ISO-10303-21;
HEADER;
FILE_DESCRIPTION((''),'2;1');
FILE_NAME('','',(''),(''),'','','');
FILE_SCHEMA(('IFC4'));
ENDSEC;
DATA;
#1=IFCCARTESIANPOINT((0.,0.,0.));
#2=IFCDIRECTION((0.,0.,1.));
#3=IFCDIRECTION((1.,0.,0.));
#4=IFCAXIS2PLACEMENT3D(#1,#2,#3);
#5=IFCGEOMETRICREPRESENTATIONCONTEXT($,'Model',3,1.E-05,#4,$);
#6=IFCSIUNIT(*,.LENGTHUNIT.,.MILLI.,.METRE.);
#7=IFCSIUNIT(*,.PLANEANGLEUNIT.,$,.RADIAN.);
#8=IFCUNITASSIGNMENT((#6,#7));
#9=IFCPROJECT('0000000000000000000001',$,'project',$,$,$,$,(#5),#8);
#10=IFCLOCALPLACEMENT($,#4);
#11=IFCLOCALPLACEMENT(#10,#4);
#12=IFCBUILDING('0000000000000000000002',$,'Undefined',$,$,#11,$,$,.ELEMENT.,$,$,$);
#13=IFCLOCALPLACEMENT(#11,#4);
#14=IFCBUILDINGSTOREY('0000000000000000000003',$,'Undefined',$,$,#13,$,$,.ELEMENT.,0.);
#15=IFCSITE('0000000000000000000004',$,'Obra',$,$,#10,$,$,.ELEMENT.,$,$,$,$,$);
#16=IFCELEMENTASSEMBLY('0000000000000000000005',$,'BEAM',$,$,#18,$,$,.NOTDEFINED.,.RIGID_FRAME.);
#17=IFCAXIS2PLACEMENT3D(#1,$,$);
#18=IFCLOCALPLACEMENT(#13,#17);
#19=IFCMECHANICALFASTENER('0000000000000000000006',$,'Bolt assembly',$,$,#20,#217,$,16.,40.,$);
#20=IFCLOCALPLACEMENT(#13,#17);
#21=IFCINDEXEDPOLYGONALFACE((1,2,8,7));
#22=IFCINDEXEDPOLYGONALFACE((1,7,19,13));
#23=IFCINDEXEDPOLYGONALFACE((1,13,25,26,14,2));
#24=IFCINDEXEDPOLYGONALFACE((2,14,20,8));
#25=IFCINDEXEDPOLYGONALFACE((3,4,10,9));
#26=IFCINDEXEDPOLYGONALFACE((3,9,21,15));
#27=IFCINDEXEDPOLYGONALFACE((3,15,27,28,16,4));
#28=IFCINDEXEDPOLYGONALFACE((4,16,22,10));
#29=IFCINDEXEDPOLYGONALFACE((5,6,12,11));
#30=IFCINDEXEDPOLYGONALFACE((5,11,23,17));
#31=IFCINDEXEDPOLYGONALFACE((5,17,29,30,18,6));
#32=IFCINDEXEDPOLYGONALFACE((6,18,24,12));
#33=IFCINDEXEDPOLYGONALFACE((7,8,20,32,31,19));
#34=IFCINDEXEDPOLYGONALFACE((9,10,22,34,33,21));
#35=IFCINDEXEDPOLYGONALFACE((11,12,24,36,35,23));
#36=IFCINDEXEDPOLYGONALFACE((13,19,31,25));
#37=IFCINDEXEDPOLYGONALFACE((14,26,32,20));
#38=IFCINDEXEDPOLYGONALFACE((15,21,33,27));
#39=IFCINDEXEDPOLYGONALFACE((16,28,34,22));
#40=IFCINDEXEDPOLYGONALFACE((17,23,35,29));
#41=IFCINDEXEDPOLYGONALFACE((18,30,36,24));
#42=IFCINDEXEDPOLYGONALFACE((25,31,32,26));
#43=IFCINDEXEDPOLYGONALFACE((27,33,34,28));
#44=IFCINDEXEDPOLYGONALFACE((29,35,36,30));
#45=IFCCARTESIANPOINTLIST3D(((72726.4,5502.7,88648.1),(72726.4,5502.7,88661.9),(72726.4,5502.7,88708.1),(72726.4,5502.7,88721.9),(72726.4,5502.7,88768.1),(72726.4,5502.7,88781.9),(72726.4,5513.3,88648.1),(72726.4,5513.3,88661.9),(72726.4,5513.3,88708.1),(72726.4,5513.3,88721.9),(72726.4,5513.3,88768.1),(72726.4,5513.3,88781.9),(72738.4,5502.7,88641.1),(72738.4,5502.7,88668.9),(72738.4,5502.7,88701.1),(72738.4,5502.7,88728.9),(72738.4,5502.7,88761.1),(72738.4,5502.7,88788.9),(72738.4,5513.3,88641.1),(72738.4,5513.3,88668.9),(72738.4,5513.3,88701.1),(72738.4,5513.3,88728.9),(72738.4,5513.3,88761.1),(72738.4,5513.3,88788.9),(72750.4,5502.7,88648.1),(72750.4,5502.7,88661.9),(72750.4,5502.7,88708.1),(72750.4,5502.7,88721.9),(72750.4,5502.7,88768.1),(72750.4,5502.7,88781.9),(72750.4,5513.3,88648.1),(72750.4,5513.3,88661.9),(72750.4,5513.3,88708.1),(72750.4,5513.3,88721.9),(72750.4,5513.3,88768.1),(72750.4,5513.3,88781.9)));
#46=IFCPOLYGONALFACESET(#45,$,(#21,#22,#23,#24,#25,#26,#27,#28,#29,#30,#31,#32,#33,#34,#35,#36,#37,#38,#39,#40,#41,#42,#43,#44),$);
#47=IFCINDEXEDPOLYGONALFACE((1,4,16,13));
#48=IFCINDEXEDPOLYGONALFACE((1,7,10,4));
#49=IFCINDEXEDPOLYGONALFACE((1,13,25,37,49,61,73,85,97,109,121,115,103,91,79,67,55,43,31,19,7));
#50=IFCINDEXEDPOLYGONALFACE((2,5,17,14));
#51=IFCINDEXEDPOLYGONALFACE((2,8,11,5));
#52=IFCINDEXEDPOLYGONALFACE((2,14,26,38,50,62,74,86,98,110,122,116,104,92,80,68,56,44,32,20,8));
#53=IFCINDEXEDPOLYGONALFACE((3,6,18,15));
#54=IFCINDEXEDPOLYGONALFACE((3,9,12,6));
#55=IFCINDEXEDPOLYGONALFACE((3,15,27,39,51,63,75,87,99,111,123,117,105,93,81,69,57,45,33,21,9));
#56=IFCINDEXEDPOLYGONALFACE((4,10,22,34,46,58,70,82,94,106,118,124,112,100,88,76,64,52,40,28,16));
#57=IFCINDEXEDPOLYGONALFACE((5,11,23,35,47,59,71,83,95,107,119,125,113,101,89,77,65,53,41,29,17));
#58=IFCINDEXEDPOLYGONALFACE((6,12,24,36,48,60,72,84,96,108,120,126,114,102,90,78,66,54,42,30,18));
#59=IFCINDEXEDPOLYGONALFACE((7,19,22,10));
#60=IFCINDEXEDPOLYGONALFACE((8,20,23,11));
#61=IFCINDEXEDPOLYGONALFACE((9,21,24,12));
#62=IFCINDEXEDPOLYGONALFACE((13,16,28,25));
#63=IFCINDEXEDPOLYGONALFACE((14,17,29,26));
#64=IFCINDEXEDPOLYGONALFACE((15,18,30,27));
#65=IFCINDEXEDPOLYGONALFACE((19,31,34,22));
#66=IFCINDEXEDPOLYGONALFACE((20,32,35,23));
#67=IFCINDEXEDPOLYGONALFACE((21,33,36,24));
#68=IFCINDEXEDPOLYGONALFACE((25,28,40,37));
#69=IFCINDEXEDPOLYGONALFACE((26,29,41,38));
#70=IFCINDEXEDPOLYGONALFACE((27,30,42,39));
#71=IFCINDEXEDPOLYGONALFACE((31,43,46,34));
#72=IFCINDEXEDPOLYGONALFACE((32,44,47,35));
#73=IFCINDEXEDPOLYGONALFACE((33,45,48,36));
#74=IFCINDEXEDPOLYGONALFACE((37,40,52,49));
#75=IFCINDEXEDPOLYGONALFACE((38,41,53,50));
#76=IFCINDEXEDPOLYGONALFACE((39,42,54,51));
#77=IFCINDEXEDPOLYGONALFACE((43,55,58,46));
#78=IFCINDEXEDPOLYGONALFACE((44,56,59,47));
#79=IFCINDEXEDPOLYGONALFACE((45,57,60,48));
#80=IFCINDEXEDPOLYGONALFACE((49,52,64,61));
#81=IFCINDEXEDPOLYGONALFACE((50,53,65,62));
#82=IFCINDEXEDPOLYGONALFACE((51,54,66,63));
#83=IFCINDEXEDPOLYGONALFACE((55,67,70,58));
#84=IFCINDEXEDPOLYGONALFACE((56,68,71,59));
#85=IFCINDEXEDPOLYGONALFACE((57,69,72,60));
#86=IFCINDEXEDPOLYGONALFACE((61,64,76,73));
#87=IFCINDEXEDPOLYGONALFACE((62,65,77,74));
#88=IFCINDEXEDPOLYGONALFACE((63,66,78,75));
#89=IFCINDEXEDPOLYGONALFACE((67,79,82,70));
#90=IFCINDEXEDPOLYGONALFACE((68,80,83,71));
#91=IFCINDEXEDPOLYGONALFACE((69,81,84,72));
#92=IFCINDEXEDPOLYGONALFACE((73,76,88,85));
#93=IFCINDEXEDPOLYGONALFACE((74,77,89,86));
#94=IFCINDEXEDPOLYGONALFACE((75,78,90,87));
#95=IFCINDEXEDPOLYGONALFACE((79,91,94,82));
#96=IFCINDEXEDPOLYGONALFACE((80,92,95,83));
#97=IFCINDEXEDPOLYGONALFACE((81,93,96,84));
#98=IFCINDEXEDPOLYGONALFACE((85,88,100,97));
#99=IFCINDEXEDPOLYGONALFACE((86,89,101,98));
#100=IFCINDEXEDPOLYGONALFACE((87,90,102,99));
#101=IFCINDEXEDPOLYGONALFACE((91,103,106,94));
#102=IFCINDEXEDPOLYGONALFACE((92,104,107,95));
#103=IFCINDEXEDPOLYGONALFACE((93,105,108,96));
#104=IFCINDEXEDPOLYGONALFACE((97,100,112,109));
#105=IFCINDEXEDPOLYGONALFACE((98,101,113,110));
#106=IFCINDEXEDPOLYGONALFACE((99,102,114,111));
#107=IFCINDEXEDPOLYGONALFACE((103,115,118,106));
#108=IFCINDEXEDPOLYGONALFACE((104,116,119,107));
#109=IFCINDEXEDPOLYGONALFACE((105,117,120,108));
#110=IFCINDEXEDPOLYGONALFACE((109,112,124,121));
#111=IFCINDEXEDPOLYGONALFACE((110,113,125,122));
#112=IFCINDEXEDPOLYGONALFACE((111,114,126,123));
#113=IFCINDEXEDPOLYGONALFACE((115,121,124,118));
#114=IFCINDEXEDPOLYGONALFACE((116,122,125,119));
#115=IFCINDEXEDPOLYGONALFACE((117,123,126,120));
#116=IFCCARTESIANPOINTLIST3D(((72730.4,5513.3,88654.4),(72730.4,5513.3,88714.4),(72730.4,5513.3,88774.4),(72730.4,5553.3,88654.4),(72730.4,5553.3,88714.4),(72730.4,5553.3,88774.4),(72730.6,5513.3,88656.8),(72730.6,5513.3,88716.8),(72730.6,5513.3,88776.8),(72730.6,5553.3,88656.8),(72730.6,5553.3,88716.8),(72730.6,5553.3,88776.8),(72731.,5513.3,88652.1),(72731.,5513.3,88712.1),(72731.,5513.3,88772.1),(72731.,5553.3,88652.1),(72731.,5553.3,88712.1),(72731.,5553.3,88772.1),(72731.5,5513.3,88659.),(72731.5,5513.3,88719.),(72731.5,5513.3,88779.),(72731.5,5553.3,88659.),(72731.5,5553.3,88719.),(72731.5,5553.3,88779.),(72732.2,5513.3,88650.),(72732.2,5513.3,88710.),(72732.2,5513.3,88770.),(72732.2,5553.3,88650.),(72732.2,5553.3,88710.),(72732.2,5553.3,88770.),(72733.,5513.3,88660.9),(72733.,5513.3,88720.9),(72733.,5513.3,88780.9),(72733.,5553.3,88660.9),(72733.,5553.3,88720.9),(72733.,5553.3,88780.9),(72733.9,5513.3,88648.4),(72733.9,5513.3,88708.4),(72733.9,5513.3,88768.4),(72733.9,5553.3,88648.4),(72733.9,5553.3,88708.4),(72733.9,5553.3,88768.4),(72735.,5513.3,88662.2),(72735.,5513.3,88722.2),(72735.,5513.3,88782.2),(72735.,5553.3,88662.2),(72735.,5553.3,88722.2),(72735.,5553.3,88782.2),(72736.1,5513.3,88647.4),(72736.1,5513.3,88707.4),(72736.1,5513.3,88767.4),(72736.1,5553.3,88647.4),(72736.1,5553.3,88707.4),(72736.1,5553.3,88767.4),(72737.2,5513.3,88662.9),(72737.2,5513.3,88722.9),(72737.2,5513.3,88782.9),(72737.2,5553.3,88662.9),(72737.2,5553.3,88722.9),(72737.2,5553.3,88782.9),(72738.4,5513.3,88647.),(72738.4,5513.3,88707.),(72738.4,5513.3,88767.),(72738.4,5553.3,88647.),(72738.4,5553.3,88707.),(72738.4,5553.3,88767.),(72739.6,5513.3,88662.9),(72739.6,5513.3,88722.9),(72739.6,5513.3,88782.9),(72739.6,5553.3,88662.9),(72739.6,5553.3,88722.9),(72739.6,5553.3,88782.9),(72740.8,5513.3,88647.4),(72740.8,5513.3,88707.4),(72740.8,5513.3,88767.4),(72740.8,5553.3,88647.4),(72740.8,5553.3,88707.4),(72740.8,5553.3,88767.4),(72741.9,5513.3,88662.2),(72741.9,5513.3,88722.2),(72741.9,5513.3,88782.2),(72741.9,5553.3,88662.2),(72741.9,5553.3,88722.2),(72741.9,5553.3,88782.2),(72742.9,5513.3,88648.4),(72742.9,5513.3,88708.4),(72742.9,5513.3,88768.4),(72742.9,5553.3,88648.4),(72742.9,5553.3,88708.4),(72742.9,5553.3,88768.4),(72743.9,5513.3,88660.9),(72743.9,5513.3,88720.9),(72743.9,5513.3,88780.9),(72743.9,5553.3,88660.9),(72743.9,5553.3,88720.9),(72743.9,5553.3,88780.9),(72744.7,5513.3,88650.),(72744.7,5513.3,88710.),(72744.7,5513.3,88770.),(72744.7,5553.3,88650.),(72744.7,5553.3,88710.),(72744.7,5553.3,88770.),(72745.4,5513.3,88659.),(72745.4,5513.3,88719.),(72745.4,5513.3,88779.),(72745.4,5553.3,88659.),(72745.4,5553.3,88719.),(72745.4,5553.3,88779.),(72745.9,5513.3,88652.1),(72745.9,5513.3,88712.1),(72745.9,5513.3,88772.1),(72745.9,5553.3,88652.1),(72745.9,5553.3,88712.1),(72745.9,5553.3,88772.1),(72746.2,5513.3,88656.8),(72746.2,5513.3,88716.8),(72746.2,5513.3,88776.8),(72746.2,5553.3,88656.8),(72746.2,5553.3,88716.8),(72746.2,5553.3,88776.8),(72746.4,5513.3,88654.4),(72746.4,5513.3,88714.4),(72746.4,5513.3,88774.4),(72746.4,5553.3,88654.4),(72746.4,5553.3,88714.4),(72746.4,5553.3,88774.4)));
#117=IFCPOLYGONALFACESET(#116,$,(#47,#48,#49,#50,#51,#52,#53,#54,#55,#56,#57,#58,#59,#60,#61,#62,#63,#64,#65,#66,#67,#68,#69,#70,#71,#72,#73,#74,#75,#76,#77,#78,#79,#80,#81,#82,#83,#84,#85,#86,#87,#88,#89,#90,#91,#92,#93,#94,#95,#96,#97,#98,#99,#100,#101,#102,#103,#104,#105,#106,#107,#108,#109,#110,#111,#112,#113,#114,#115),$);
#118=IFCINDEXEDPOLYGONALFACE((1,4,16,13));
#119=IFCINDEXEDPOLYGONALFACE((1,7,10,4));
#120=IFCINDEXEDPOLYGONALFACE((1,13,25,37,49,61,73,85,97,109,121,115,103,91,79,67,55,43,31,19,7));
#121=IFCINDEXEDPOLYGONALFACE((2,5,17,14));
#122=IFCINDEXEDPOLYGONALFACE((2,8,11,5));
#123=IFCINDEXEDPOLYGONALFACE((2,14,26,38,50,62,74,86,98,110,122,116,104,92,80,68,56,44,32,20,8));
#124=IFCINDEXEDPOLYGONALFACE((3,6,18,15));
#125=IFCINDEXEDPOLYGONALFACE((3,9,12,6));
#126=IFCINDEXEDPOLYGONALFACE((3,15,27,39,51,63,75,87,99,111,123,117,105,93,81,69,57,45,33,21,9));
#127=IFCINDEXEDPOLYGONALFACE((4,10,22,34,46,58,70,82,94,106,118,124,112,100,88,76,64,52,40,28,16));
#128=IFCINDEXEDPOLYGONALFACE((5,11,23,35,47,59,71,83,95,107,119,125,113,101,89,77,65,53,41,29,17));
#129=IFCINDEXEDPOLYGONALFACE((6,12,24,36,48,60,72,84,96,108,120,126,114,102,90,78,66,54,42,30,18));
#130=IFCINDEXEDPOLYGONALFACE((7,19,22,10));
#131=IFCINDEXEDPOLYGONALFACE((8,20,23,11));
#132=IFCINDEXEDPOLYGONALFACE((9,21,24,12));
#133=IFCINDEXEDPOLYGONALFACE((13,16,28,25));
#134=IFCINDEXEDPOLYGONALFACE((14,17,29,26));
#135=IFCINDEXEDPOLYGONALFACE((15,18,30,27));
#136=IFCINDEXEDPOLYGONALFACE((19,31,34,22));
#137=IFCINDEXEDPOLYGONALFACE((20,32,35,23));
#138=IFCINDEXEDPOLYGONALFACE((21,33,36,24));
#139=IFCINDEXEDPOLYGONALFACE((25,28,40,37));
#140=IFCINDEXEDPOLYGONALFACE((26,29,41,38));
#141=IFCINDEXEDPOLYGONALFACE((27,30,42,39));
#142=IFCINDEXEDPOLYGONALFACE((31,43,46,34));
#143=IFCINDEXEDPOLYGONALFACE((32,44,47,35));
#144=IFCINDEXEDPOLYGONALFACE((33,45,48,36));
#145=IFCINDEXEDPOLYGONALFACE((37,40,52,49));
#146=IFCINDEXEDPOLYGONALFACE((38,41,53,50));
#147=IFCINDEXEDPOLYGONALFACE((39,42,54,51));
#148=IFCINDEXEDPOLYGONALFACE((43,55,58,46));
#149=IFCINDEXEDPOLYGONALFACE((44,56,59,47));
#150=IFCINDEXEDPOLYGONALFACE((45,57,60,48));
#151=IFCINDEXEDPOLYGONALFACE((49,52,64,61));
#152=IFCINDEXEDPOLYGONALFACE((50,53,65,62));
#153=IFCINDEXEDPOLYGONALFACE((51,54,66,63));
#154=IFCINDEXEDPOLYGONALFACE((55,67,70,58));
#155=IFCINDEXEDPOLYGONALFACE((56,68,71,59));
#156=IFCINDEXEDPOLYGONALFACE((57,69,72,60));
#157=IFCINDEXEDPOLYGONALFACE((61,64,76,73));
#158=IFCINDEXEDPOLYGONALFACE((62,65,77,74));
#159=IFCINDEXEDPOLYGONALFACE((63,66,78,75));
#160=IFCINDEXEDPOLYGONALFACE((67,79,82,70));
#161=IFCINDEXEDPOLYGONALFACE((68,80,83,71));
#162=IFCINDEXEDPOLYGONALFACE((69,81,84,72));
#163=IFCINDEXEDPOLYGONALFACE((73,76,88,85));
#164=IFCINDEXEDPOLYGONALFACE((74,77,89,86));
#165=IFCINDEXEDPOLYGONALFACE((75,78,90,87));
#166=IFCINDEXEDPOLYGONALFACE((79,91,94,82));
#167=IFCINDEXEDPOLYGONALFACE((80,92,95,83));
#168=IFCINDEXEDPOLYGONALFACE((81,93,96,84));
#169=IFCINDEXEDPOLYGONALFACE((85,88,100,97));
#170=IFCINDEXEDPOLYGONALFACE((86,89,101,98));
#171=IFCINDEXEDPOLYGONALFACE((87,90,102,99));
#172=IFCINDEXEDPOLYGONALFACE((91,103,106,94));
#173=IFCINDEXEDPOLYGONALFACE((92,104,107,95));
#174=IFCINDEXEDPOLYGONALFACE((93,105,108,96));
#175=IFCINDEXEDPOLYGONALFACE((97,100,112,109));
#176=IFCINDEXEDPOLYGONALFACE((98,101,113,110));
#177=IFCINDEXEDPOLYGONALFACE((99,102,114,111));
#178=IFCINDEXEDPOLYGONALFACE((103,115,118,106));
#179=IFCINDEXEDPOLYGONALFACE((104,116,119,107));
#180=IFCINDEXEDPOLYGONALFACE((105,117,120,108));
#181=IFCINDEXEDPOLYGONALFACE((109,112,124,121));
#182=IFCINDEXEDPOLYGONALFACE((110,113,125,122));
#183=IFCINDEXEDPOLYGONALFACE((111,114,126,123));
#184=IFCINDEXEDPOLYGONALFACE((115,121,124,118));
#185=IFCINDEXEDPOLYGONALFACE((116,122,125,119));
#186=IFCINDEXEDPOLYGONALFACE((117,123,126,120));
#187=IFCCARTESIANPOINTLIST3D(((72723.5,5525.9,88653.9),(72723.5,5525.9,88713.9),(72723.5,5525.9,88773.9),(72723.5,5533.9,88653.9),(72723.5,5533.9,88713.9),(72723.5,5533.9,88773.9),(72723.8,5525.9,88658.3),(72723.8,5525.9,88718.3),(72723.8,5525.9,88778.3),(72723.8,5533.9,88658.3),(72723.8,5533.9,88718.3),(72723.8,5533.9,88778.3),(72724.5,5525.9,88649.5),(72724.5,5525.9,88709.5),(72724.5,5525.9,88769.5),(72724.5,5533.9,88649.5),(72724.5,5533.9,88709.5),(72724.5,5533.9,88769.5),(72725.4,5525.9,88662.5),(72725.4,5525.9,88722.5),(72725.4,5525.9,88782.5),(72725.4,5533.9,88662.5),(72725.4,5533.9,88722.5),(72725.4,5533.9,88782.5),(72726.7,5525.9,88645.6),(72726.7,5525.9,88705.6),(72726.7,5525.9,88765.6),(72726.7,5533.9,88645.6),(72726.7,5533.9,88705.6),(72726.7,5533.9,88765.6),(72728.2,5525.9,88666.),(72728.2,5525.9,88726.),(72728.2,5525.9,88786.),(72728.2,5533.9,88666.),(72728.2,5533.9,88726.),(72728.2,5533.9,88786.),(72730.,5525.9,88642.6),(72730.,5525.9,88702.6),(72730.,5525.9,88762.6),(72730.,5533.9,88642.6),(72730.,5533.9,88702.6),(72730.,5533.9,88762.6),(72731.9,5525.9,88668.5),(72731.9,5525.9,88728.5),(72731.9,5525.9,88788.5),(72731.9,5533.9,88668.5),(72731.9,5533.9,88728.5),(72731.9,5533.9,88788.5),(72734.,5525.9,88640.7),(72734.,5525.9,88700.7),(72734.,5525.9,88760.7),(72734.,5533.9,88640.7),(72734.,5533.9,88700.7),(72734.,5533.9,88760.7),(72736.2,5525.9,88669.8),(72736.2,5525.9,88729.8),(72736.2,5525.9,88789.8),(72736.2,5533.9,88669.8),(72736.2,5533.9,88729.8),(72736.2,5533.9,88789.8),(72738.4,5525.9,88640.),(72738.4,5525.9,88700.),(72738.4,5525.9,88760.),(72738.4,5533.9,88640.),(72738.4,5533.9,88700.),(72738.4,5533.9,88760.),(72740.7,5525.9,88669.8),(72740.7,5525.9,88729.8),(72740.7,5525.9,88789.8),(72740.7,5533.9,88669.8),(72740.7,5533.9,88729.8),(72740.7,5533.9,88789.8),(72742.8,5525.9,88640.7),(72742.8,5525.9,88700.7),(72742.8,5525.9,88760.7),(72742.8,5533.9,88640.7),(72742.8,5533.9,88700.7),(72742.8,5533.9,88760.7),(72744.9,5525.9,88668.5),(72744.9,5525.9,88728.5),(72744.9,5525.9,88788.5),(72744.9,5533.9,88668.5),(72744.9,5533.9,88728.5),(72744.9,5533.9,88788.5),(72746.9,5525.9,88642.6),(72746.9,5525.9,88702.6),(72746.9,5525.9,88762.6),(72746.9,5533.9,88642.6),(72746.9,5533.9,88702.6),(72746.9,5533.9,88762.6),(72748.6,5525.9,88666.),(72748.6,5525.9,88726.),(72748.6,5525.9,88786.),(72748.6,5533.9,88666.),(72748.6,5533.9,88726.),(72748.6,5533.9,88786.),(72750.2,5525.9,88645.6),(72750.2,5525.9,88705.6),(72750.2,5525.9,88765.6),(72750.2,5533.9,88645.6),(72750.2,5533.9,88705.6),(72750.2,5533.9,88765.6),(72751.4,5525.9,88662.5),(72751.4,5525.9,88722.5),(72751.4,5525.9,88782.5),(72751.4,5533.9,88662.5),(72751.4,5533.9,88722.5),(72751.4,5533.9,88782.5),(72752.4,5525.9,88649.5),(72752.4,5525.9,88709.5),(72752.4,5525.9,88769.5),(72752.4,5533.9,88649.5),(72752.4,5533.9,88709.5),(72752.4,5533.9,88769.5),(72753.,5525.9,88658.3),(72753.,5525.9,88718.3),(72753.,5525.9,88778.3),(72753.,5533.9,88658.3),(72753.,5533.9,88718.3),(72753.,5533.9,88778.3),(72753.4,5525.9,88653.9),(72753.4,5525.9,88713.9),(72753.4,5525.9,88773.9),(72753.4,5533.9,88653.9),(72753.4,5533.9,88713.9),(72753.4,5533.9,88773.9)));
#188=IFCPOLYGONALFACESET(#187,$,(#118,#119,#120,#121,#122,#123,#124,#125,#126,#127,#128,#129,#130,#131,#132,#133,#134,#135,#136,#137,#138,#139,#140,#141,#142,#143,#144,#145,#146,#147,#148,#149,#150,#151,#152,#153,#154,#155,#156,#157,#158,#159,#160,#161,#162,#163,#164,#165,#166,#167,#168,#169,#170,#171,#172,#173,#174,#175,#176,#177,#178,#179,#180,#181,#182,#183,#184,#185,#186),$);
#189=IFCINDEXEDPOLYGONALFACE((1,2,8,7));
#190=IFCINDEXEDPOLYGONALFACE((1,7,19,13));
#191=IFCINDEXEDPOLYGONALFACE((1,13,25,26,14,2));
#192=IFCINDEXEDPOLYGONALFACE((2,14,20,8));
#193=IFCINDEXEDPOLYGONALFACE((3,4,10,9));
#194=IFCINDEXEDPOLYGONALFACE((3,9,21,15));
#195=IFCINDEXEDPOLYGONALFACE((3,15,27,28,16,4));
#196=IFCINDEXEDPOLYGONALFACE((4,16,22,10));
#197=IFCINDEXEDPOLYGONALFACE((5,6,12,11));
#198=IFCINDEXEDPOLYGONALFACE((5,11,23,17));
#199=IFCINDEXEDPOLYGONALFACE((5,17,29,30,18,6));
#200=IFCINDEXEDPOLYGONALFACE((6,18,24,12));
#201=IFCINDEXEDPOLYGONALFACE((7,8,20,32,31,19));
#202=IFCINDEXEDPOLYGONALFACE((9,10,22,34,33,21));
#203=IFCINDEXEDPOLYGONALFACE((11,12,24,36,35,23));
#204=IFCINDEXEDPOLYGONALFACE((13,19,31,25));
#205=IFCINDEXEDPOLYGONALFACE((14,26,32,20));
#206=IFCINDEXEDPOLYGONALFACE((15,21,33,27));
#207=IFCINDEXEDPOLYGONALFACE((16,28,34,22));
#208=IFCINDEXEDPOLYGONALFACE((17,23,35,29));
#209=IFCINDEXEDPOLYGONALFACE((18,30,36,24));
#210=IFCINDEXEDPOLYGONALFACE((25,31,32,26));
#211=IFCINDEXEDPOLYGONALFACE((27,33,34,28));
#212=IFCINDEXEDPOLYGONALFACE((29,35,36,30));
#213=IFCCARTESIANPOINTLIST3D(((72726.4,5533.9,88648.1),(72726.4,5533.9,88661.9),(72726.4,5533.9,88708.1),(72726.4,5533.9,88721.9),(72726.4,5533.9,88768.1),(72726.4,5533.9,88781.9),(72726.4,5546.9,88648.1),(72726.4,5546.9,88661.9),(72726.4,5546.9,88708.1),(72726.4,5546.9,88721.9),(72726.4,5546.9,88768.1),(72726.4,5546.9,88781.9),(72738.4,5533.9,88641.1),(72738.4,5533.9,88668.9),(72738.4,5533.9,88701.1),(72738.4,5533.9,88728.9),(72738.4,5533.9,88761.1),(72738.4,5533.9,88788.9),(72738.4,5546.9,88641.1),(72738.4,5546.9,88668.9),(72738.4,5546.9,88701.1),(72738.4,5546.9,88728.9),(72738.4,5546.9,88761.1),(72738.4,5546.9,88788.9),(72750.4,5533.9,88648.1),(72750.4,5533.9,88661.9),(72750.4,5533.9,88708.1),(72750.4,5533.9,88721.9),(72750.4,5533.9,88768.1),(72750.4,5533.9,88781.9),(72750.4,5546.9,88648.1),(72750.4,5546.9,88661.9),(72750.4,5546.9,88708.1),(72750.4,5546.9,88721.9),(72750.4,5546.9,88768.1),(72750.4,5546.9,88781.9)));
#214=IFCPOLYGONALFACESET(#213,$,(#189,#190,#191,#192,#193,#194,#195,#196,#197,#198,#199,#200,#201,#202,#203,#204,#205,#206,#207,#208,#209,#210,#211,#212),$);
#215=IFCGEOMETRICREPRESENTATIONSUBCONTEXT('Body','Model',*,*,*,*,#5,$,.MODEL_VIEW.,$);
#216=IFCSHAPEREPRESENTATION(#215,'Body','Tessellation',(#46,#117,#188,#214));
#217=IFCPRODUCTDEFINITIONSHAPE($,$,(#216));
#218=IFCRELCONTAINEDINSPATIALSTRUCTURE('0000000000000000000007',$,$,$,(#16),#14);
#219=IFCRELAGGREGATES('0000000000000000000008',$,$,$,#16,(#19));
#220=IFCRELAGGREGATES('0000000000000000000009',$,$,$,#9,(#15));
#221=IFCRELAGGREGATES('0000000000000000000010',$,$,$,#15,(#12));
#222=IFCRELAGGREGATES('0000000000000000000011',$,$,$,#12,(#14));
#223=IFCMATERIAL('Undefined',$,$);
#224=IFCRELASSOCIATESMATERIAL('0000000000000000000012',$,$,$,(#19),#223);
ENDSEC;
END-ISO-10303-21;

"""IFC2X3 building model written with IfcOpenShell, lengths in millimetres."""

from ifc_helpers import new_model, si_unit, frame, origin_with_axes, origin_2d_with_axis, place, context, subcontext, project, spatial, polyline, circle, outline, extrude, source, transform, mapped, material, element, aggregate, save


model = new_model("IFC2X3")

# Units and contexts
model_context = context("Model", 3, precision=1e-05, world=origin_with_axes())
body_context = subcontext(model_context, "Body", "Model", "MODEL_VIEW")
ifc_project = project(units=[si_unit("LENGTHUNIT", "METRE", prefix="MILLI"), si_unit("PLANEANGLEUNIT", "RADIAN")], contexts=[model_context])

# Site, building, storey
site_placement = place(None, origin_with_axes())
site = spatial("IfcSite", under=ifc_project, at=site_placement, Name="Obra", CompositionType="ELEMENT")
building_placement = place(site_placement, origin_with_axes())
building = spatial("IfcBuilding", under=site, at=building_placement, Name="Undefined", CompositionType="ELEMENT")
storey_placement = place(building_placement, origin_with_axes())
storey = spatial("IfcBuildingStorey", under=building, at=storey_placement, Name="Undefined", CompositionType="ELEMENT", Elevation=0.0)

# Element assembly, mechanical fastener
assembly_1_placement = place(storey_placement, origin_with_axes())
assembly_1 = element("IfcElementAssembly", 1, at=assembly_1_placement, inside=storey, Name="BEAM", AssemblyPlace="NOTDEFINED", PredefinedType="RIGID_FRAME")
ifc_material_1 = material(Name="Undefined")
shared_shape_1 = source(origin_with_axes(), body_context, "Body", "SweptSolid", [
    extrude(outline(polyline([(13.9, 0.0), (6.9, 12.0), (-6.9, 12.0), (-13.9, 0.0), (-6.9, -12.0), (6.9, -12.0), (13.9, 0.0)])), frame((0.0, -19.9, 0.0), z_axis=(0.0, 1.0, 0.0), x_axis=(1.0, 0.0, 0.0)), (0.0, 0.0, 1.0), 10.6),
    extrude(circle(Radius=8.0, at=origin_2d_with_axis()), frame((0.0, -9.3, 0.0), z_axis=(0.0, 1.0, 0.0), x_axis=(1.0, 0.0, 0.0)), (0.0, 0.0, 1.0), 40.0),
    extrude(circle(Radius=15.0, at=origin_2d_with_axis()), frame((0.0, 3.3, 0.0), z_axis=(0.0, 1.0, 0.0), x_axis=(1.0, 0.0, 0.0)), (0.0, 0.0, 1.0), 8.0),
    extrude(outline(polyline([(13.9, 0.0), (6.9, 12.0), (-6.9, 12.0), (-13.9, 0.0), (-6.9, -12.0), (6.9, -12.0), (13.9, 0.0)])), frame((0.0, 11.3, 0.0), z_axis=(0.0, 1.0, 0.0), x_axis=(1.0, 0.0, 0.0)), (0.0, 0.0, 1.0), 13.0),
])
mechanical_fastener_1_placement = place(assembly_1_placement, frame((72688.4, 5522.6, 88850.0), z_axis=(1.0, 0.0, 0.0), x_axis=(0.0, 0.0, -1.0)))
mechanical_fastener_1 = element("IfcMechanicalFastener", 2, at=mechanical_fastener_1_placement, material=ifc_material_1, Name="Bolt assembly", NominalDiameter=16.0, NominalLength=40.0, context=body_context, shape_type="MappedRepresentation", body=[
    mapped(shared_shape_1, transform((75.0, 0.0, 50.0))),
    mapped(shared_shape_1, transform((135.0, 0.0, 50.0))),
    mapped(shared_shape_1, transform((195.0, 0.0, 50.0))),
])
aggregate(assembly_1, [mechanical_fastener_1])

save(model, "model.ifc")
